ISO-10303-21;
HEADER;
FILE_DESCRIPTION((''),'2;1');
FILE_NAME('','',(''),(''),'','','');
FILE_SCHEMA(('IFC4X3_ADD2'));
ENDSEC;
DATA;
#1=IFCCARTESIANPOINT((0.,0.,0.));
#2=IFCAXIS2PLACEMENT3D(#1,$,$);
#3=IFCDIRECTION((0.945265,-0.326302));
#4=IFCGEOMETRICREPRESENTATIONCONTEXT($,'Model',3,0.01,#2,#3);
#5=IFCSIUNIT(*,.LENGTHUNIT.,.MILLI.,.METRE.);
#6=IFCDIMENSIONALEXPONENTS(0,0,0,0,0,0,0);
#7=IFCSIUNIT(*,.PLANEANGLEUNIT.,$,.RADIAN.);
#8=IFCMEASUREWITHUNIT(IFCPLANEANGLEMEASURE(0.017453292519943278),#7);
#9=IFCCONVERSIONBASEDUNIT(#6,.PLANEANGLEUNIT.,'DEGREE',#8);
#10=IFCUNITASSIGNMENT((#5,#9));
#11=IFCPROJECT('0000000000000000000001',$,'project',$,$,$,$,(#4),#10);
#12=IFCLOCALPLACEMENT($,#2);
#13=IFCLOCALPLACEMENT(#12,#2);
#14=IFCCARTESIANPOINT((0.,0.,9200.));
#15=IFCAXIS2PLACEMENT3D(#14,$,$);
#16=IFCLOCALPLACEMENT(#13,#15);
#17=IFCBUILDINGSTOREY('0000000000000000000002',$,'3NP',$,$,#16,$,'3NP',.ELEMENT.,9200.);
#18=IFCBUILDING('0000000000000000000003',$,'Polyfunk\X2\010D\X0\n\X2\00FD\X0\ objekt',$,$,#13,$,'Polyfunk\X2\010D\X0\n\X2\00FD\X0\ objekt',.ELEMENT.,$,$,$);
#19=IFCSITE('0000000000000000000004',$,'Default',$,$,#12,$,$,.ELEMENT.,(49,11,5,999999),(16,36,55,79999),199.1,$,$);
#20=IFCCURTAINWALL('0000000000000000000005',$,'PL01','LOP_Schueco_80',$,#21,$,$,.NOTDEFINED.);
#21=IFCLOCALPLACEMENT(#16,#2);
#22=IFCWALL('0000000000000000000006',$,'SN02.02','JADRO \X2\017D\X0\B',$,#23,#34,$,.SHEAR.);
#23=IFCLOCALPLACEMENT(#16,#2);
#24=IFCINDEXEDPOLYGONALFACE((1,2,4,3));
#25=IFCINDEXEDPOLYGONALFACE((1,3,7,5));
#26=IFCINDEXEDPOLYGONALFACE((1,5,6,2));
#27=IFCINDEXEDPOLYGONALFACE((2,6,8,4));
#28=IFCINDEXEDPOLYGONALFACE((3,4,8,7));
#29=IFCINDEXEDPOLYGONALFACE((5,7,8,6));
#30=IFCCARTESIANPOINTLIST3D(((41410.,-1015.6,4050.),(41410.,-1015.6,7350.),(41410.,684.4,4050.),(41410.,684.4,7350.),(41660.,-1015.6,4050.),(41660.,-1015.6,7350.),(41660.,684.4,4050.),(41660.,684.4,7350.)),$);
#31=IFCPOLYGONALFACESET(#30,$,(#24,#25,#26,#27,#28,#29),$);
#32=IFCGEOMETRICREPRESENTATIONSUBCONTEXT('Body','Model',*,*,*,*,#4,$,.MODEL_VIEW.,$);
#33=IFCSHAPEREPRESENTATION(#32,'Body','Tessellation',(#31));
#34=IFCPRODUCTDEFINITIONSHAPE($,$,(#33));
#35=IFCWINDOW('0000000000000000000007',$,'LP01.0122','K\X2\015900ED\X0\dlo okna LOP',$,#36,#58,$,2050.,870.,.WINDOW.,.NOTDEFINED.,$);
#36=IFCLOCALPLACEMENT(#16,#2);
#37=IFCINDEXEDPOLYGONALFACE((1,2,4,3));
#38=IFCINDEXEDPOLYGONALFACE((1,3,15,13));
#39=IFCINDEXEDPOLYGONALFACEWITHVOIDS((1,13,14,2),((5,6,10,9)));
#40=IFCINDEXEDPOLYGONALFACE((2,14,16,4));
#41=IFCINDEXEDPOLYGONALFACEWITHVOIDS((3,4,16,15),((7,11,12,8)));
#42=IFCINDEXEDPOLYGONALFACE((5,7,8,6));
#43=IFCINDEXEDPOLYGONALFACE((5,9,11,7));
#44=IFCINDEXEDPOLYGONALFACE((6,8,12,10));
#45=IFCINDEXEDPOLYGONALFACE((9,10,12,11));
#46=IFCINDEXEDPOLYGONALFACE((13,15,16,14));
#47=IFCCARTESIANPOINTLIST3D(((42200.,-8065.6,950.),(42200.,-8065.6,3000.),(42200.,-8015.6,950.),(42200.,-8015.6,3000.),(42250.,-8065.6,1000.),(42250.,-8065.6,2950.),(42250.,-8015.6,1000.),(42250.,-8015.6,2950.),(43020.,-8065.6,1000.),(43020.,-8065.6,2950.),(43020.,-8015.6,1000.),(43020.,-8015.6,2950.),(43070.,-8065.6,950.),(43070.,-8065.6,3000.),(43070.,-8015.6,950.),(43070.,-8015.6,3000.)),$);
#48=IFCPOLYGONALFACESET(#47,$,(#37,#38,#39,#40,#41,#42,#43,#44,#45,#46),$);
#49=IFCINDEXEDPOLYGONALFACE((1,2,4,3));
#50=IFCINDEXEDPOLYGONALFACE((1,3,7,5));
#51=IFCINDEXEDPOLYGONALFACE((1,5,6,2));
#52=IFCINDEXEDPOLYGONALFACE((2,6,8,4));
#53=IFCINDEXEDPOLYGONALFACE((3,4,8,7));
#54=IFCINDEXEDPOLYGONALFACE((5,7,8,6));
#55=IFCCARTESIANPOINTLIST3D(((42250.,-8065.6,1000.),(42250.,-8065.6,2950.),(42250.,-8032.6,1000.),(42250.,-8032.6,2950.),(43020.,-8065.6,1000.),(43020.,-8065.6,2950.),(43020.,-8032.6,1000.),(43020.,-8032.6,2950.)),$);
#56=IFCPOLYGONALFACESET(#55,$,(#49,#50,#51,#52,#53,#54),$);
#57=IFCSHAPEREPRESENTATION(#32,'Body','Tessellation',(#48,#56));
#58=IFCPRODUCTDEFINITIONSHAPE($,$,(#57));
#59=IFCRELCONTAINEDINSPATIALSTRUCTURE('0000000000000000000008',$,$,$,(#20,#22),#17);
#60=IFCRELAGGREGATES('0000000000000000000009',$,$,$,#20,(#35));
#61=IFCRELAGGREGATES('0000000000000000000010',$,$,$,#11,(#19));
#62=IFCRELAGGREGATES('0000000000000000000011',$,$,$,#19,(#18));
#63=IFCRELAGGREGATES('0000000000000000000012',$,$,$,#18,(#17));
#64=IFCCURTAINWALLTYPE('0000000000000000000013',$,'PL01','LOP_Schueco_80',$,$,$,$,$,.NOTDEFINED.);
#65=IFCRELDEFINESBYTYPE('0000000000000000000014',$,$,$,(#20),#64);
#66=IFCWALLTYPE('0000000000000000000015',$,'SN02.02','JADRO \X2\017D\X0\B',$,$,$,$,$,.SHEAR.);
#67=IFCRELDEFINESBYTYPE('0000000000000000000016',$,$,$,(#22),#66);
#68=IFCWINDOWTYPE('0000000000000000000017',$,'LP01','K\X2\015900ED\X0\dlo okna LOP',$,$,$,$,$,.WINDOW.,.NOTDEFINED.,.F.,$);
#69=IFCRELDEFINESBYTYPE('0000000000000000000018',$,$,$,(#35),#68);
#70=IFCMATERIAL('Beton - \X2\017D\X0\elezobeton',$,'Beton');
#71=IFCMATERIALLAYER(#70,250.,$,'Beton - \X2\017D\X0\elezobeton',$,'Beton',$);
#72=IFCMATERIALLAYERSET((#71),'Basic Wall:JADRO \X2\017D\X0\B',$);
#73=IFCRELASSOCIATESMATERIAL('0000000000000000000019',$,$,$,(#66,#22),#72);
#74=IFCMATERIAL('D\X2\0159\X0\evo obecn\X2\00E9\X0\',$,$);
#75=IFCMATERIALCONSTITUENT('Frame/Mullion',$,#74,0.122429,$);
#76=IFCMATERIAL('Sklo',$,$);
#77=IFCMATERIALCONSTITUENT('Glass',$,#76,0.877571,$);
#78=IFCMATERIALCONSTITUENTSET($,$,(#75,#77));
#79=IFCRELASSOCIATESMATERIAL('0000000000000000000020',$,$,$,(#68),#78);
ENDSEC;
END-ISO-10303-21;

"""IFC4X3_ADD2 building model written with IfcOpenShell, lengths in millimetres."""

from ifc_helpers import new_model, entity, si_unit, converted_unit, direction, frame, frame_2d, origin, place, context, subcontext, project, spatial, polyline, rectangle, outline, extrude, clip, bounded_halfspace, source, transform, mapped, material, layer, layer_set, constituent, constituent_set, type_object, type_shapes, element, aggregate, save


model = new_model("IFC4X3_ADD2")

# Units and contexts
model_context = context("Model", 3, precision=0.01, world=origin(), true_north=direction((0.945265, -0.326302)))
body_context = subcontext(model_context, "Body", "Model", "MODEL_VIEW")
ifc_project = project(units=[si_unit("LENGTHUNIT", "METRE", prefix="MILLI"), converted_unit("PLANEANGLEUNIT", "DEGREE", entity("IfcPlaneAngleMeasure", 0.017453292519943278), si_unit("PLANEANGLEUNIT", "RADIAN"), dimensions=[0, 0, 0, 0, 0, 0, 0])], contexts=[model_context])

# Site, building, storey
site_placement = place(None, origin())
site = spatial("IfcSite", under=ifc_project, at=site_placement, Name="Default", CompositionType="ELEMENT", RefLatitude=(49, 11, 5, 999999), RefLongitude=(16, 36, 55, 79999), RefElevation=199.1)
building_placement = place(site_placement, origin())
building = spatial("IfcBuilding", under=site, at=building_placement, Name="Polyfunkčný objekt", LongName="Polyfunkčný objekt", CompositionType="ELEMENT")
storey_placement = place(building_placement, frame((0.0, 0.0, 9200.0)))
storey = spatial("IfcBuildingStorey", under=building, at=storey_placement, Name="3NP", LongName="3NP", CompositionType="ELEMENT", Elevation=9200.0)

# Curtain wall
curtain_wall_type = type_object("IfcCurtainWallType", Name="PL01", Description="LOP_Schueco_80", PredefinedType="NOTDEFINED")
curtain_wall_placement = place(storey_placement, frame((0.0, 0.0, -9200.0)))
curtain_wall = element("IfcCurtainWall", 1, at=curtain_wall_placement, inside=storey, type_object=curtain_wall_type, Name="PL01", Description="LOP_Schueco_80", PredefinedType="NOTDEFINED")
ifc_material_1 = material(Name="Sklo")

# Wall
ifc_material_2 = material(Name="Beton - Železobeton", Category="Beton")
ifc_layer_1 = layer(ifc_material_2, 250.0, Name="Beton - Železobeton", Category="Beton")
ifc_layer_set_1 = layer_set([ifc_layer_1], Name="Basic Wall:JADRO ŽB")
wall_type = type_object("IfcWallType", Name="SN02.02", Description="JADRO ŽB", PredefinedType="SHEAR", material=ifc_layer_set_1)
wall_1_placement = place(storey_placement, frame((41535.0, 684.4, 4050.0), z_axis=(0.0, 0.0, 1.0), x_axis=(0.0, -1.0, 0.0)))
element("IfcWall", 2, at=wall_1_placement, inside=storey, type_object=wall_type, material=ifc_layer_set_1, Name="SN02.02", Description="JADRO ŽB", PredefinedType="SHEAR", context=body_context, shape_type="Clipping", body=[
    clip(clip(extrude(rectangle(XDim=1700.0, YDim=250.0, at=frame_2d((850.0, 0.0), x_axis=(-1.0, 0.0))), origin(), (0.0, 0.0, 1.0), 3300.0), bounded_halfspace(frame((1700.0, -125.0, 0.0), z_axis=(0.0, 0.0, 1.0), x_axis=(0.0, -1.0, 0.0)), True, frame((1700.0, -125.0, 0.0)), polyline([(0.0, 0.0), (0.0, 250.0), (-1700.0, 250.0), (-1700.0, 0.0), (0.0, 0.0)]))), bounded_halfspace(frame((0.0, -125.0, 3300.0), z_axis=(0.0, 0.0, -1.0), x_axis=(1.0, 0.0, 0.0)), True, frame((0.0, -125.0, 3300.0)), polyline([(0.0, 0.0), (1700.0, 0.0), (1700.0, 250.0), (0.0, 250.0), (0.0, 0.0)]))),
])

# Window
ifc_material_3 = material(Name="Dřevo obecné")
ifc_constituent_1 = constituent(ifc_material_3, Name="Frame/Mullion", fraction=0.122429)
ifc_constituent_2 = constituent(ifc_material_1, Name="Glass", fraction=0.877571)
ifc_constituent_set = constituent_set(constituents=[ifc_constituent_1, ifc_constituent_2])
window_type = type_object("IfcWindowType", Name="LP01", Description="Křídlo okna LOP", ParameterTakesPrecedence=False, PartitioningType="NOTDEFINED", PredefinedType="WINDOW", material=ifc_constituent_set)
shared_shape_1 = source(origin(), body_context, "Body", "SweptSolid", [
    extrude(outline(polyline([(-1025.0, -435.0), (1025.0, -435.0), (1025.0, 435.0), (-1025.0, 435.0), (-1025.0, -435.0)]), holes=[polyline([(-975.0, -385.0), (-975.0, 385.0), (975.0, 385.0), (975.0, -385.0), (-975.0, -385.0)])]), frame((0.0, 50.0, 1025.0), z_axis=(0.0, -1.0, 0.0), x_axis=(0.0, 0.0, -1.0)), (0.0, 0.0, 1.0), 50.0),
    extrude(rectangle(XDim=770.0, YDim=33.0, at=frame_2d((0.0, 0.0), x_axis=(1.0, 0.0))), frame((0.0, 33.5, 50.0), z_axis=(0.0, 0.0, 1.0), x_axis=(-1.0, 0.0, 0.0)), (0.0, 0.0, 1.0), 1950.0),
])
type_shapes(window_type, [shared_shape_1])
window_placement = place(curtain_wall_placement, frame((42635.0, -8015.6, 10150.0), z_axis=(0.0, 0.0, 1.0), x_axis=(-1.0, 0.0, 0.0)))
window = element("IfcWindow", 3, at=window_placement, type_object=window_type, Name="LP01.0122", Description="Křídlo okna LOP", OverallHeight=2050.0, OverallWidth=870.0, PartitioningType="NOTDEFINED", PredefinedType="WINDOW", context=body_context, shape_type="MappedRepresentation", body=[
    mapped(shared_shape_1, transform((0.0, 0.0, 0.0), scale=1.0)),
])
aggregate(curtain_wall, [window])

save(model, "model.ifc")
